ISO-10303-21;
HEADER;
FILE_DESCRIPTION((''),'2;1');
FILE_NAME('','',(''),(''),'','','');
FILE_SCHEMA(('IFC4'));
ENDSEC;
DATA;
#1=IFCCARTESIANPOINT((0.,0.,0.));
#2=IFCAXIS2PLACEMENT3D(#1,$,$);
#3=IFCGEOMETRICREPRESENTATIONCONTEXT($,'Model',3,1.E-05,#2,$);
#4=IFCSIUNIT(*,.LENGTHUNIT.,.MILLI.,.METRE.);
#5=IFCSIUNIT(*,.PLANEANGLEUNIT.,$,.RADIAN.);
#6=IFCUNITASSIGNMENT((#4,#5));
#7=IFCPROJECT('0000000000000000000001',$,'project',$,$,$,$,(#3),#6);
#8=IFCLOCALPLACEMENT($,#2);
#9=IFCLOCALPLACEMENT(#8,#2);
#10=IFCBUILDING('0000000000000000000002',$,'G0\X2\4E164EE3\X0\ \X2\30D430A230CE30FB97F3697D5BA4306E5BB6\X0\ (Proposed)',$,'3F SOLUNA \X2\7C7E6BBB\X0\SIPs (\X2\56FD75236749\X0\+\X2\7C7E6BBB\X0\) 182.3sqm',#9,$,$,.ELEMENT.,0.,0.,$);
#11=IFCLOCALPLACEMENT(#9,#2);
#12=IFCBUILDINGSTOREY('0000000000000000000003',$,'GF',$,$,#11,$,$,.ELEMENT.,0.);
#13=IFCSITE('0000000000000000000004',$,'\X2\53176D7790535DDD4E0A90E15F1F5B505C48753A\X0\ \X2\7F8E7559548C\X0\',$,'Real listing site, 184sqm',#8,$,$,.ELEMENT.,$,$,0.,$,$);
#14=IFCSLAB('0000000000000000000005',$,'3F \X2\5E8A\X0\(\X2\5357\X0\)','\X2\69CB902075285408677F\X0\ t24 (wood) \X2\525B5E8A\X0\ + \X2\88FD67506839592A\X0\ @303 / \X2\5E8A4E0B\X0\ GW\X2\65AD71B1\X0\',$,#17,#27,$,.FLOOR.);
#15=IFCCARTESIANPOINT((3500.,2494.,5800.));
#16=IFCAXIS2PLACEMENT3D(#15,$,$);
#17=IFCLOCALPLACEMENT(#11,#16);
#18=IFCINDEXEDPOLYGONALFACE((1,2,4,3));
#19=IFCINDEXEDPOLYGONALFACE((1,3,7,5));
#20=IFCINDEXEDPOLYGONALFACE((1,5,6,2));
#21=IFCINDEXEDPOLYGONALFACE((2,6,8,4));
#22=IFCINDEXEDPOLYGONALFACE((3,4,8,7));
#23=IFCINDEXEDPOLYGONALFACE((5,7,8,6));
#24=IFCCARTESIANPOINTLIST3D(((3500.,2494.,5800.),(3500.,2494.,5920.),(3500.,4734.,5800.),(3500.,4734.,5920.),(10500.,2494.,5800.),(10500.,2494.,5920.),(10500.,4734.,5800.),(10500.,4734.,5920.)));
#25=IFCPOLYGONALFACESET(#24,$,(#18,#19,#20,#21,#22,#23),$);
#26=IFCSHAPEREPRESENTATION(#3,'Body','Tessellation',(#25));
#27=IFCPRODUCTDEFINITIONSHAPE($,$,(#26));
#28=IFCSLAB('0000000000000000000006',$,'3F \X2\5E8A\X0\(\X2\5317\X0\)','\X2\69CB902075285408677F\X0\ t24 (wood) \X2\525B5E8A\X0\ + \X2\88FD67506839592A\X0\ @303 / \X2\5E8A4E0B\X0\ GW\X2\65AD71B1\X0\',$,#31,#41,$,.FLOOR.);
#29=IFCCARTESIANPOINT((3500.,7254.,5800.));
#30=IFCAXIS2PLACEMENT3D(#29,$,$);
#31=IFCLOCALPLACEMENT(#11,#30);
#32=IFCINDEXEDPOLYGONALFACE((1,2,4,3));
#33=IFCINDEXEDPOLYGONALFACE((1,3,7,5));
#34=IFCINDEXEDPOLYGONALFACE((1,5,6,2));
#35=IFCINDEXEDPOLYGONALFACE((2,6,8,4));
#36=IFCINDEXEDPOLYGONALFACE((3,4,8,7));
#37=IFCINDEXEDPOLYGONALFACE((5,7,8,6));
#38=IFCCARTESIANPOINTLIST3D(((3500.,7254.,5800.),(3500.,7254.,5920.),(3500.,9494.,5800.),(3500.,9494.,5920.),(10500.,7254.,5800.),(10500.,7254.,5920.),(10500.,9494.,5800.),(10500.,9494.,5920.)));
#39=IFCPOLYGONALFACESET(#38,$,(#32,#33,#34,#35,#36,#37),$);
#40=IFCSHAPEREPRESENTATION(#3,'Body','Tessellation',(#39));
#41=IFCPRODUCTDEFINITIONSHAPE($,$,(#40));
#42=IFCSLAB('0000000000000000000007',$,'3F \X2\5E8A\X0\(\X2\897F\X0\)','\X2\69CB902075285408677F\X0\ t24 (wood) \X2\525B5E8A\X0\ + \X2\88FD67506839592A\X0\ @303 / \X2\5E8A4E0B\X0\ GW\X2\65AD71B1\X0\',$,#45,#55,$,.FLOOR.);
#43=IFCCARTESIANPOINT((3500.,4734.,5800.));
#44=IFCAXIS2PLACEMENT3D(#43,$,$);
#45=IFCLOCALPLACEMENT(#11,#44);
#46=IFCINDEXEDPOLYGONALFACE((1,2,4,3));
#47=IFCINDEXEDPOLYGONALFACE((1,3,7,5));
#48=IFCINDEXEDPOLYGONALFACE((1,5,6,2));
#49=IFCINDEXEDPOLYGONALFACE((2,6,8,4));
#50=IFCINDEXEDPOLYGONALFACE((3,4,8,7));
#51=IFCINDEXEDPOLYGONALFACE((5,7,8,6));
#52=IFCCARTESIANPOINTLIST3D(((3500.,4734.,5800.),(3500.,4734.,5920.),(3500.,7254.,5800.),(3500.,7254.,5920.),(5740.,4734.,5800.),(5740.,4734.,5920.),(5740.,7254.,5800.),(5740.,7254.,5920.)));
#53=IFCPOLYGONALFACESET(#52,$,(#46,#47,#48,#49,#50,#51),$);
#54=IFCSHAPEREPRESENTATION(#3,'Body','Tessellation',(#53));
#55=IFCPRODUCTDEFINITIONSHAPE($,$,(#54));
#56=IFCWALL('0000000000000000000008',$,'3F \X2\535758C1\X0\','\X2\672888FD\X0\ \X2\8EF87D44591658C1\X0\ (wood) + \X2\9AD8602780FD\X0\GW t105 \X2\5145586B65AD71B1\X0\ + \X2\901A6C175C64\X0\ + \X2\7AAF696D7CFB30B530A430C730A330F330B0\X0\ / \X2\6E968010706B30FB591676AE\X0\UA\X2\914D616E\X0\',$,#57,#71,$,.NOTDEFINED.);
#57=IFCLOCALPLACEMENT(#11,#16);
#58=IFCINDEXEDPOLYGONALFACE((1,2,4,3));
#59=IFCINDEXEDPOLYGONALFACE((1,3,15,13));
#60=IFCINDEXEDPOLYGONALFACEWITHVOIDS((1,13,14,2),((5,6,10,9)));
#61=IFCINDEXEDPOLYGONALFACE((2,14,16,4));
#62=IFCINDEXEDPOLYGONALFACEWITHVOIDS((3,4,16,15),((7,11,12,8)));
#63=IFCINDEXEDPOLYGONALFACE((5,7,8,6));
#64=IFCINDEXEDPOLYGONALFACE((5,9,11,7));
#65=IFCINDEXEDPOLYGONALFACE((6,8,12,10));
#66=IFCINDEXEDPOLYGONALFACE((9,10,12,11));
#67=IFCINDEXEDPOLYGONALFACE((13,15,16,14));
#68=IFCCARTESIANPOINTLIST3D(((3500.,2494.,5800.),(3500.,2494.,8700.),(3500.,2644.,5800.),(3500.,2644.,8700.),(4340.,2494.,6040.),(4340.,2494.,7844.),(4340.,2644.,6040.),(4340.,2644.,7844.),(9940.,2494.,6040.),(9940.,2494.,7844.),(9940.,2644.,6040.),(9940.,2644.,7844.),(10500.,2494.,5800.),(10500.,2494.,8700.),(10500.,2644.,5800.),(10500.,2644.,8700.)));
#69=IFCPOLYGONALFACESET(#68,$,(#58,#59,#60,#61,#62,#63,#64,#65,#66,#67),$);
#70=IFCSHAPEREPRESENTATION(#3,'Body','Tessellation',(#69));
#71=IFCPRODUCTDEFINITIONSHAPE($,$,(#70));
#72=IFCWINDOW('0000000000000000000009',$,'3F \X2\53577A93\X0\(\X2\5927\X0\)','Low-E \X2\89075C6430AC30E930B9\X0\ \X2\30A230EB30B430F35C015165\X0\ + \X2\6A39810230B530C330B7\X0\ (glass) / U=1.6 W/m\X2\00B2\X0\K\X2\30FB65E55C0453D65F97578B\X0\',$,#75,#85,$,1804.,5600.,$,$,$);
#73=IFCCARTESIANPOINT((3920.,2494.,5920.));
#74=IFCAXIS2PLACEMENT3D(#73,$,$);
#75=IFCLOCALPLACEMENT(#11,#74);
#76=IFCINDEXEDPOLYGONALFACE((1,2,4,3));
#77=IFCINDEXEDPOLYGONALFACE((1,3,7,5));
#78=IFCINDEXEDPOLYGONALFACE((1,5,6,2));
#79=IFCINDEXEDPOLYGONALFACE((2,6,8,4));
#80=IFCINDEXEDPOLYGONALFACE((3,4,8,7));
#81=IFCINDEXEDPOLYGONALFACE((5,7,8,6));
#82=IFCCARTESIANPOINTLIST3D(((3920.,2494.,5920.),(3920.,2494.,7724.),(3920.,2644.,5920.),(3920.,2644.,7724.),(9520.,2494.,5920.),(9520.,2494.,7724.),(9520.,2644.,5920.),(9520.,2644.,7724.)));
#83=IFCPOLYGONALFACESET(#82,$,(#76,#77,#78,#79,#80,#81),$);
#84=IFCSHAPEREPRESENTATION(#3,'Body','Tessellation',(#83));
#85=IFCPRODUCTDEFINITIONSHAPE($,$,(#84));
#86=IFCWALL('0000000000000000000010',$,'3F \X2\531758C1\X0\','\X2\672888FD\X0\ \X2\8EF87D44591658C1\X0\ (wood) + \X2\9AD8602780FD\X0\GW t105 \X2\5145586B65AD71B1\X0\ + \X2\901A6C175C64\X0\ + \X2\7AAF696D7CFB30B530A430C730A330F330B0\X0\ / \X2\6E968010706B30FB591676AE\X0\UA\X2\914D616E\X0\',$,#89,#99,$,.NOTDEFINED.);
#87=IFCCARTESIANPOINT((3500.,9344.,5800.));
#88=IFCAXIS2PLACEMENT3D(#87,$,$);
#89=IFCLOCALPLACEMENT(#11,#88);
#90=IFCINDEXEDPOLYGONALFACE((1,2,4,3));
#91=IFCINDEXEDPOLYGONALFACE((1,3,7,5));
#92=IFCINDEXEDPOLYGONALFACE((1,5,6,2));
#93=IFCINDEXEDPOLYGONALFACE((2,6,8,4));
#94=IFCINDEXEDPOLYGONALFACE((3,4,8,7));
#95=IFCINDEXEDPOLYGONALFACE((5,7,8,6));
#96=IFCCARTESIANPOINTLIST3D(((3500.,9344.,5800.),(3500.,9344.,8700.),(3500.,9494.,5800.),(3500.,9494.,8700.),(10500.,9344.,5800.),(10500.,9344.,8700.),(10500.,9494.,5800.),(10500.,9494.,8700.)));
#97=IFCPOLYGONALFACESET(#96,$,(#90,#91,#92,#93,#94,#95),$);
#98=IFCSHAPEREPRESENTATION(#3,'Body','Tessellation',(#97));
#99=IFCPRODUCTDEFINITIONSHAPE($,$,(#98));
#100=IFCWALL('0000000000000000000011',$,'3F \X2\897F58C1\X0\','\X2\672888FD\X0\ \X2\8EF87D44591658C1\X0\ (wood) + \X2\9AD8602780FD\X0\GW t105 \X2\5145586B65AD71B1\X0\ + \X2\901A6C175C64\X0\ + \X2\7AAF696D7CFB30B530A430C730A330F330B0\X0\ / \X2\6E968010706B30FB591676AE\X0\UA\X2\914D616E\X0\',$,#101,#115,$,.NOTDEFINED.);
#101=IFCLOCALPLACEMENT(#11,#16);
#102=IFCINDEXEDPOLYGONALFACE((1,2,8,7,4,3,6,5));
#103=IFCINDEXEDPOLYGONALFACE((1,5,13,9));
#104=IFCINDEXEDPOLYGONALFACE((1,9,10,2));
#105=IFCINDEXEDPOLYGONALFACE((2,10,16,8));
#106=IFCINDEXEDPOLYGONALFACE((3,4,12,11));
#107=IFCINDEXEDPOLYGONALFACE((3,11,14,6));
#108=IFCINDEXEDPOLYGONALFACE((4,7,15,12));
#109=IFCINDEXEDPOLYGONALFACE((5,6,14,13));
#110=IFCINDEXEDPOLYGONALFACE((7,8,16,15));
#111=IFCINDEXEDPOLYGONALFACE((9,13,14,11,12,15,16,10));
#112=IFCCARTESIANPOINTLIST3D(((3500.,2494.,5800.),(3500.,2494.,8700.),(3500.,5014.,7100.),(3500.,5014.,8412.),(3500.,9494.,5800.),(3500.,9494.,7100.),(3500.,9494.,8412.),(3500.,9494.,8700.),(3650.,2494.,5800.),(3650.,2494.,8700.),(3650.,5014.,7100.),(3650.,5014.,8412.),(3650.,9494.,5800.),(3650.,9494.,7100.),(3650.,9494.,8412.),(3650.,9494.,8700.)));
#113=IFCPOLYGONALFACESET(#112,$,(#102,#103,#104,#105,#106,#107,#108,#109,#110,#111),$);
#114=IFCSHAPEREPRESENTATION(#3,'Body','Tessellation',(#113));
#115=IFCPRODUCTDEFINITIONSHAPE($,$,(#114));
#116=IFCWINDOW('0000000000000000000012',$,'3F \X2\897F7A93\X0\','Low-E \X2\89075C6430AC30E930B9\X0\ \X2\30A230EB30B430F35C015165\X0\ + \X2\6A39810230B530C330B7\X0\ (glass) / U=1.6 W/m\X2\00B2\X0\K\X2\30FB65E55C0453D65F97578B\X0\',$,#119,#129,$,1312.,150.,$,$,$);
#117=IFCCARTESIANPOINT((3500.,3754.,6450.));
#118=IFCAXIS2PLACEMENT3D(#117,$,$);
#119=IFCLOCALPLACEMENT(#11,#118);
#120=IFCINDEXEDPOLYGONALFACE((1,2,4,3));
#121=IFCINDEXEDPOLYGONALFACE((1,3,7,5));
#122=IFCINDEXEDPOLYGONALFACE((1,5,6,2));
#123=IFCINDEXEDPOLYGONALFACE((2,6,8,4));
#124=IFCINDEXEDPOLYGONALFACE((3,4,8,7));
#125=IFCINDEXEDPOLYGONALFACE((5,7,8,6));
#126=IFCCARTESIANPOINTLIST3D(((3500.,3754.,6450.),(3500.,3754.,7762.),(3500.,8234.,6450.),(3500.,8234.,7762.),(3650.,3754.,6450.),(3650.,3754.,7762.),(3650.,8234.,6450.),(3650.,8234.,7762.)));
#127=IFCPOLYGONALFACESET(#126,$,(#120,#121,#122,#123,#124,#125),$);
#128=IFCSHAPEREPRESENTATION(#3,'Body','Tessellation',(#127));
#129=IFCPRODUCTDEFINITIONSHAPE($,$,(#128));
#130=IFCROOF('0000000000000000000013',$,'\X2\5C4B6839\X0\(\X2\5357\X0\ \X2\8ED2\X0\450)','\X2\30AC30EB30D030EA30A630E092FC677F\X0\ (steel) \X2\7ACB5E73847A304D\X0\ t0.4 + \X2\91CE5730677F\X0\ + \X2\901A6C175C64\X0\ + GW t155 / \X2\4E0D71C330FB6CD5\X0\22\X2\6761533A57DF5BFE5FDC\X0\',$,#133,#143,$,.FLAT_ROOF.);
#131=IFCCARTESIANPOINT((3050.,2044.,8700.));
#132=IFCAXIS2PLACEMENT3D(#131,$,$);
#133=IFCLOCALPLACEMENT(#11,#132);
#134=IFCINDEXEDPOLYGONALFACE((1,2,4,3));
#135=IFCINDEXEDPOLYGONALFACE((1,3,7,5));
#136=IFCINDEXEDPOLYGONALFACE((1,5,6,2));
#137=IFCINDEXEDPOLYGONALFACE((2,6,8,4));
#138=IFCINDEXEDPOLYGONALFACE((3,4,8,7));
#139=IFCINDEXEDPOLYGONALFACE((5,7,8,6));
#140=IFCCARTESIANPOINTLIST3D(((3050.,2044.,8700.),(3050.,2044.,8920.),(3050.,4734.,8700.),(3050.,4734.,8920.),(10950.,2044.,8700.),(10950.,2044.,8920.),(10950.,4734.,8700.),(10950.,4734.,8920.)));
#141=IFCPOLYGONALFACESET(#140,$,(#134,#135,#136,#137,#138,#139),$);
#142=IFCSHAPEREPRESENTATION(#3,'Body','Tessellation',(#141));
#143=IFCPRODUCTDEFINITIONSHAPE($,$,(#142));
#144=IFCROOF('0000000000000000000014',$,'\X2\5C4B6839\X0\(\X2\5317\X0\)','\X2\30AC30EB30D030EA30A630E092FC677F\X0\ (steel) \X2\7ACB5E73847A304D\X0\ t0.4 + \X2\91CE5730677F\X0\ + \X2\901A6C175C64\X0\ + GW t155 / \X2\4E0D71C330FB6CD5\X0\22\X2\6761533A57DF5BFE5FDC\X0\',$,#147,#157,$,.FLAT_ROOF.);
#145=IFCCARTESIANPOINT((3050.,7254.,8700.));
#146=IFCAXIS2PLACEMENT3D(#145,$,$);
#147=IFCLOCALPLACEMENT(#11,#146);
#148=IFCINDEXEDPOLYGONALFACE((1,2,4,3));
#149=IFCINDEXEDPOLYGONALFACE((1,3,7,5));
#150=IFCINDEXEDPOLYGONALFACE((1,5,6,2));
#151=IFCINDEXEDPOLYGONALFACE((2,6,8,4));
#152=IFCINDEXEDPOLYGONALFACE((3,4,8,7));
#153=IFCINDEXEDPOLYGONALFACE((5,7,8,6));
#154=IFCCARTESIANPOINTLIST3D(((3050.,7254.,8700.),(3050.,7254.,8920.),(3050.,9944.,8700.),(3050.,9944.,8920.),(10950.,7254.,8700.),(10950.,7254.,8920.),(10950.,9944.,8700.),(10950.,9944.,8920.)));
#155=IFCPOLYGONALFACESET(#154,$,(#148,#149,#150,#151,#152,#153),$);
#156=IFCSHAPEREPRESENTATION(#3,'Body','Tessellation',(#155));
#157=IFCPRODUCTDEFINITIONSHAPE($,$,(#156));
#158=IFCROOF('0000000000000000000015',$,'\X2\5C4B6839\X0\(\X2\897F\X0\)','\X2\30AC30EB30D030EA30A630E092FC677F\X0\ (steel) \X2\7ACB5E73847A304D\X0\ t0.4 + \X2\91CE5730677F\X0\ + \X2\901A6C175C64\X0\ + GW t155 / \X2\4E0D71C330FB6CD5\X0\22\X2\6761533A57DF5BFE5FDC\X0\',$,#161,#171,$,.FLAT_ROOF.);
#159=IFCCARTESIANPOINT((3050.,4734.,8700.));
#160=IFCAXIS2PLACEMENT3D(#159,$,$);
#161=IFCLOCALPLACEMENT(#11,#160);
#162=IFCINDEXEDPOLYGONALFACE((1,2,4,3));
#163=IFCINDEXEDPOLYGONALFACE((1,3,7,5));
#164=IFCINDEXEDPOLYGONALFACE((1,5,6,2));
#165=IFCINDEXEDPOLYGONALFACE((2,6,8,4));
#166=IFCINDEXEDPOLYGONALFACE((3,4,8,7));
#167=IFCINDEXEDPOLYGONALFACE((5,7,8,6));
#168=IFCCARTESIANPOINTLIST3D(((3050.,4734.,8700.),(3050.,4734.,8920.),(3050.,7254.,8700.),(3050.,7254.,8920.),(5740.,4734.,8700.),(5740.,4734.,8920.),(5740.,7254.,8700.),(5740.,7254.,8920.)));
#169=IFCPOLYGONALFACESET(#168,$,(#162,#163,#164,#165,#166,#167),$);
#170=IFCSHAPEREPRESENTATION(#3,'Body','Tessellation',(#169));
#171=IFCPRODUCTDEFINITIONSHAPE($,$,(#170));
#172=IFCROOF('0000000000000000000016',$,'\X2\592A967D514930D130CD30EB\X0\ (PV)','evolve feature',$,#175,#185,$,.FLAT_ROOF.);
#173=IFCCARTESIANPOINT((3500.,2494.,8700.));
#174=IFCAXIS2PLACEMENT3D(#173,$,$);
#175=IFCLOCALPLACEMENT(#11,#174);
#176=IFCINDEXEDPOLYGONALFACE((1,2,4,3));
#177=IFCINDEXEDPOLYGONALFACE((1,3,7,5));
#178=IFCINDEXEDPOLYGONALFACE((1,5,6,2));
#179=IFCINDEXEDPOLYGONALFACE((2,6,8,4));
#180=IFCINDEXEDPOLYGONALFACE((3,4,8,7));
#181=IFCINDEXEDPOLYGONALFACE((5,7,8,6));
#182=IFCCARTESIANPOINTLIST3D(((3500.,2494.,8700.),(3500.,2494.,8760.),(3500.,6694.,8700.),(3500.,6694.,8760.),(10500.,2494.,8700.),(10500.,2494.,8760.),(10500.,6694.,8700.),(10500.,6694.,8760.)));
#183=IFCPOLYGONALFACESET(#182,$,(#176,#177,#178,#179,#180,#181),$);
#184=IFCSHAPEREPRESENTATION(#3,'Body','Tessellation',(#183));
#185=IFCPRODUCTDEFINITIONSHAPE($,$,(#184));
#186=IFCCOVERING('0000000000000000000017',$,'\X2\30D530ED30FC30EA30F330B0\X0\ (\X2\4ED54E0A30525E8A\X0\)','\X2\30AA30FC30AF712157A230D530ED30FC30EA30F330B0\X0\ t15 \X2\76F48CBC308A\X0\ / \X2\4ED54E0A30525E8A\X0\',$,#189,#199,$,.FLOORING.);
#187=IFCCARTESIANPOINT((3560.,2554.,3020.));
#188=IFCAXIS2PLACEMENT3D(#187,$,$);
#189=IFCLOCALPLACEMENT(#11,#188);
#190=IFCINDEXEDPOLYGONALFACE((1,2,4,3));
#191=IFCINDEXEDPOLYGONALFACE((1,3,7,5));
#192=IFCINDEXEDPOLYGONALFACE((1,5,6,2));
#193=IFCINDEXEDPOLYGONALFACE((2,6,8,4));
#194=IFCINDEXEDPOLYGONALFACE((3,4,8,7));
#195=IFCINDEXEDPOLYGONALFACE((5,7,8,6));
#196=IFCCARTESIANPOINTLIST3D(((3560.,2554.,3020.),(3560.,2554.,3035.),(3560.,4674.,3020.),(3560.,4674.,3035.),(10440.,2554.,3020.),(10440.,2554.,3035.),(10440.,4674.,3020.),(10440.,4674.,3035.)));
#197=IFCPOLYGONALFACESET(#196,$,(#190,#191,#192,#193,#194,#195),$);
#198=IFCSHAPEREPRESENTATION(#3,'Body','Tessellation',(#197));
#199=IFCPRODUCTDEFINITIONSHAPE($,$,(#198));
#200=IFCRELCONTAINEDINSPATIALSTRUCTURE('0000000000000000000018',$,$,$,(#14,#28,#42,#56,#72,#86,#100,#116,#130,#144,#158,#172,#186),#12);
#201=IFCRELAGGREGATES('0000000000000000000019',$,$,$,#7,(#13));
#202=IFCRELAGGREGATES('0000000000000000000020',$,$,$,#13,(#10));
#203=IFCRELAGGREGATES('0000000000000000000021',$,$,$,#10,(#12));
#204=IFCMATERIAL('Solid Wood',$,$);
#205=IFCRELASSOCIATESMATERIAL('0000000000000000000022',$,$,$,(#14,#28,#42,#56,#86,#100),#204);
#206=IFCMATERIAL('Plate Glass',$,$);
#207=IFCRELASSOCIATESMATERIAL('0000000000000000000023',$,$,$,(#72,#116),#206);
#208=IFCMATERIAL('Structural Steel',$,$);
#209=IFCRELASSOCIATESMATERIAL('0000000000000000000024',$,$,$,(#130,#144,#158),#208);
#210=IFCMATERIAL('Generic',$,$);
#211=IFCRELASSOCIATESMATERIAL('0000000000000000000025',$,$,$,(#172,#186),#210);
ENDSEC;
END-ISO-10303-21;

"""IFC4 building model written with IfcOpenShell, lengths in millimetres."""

from ifc_helpers import new_model, si_unit, frame, frame_2d, origin, place, context, project, spatial, rectangle, extrude, material, element, fill, save


model = new_model("IFC4")

# Units and contexts
model_context = context("Model", 3, precision=1e-05, world=origin())
ifc_project = project(units=[si_unit("LENGTHUNIT", "METRE", prefix="MILLI"), si_unit("PLANEANGLEUNIT", "RADIAN")], contexts=[model_context])

# Site, building, storey
site_placement = place(None, origin())
site = spatial("IfcSite", under=ifc_project, at=site_placement, Name="北海道川上郡弟子屈町 美留和", ObjectType="Real listing site, 184sqm", CompositionType="ELEMENT", RefElevation=0.0)
building_placement = place(site_placement, origin())
building = spatial("IfcBuilding", under=site, at=building_placement, Name="G0世代 ピアノ・音楽室の家 (Proposed)", ObjectType="3F SOLUNA 籾殻SIPs (国産杉+籾殻) 182.3sqm", CompositionType="ELEMENT", ElevationOfRefHeight=0.0, ElevationOfTerrain=0.0)
storey_placement = place(building_placement, origin())
storey = spatial("IfcBuildingStorey", under=building, at=storey_placement, Name="GF", CompositionType="ELEMENT", Elevation=0.0)

# Slabs
ifc_material_1 = material(Name="Solid Wood")
slab_1_placement = place(storey_placement, frame((3500.0, 2494.0, 5800.0)))
element("IfcSlab", 1, at=slab_1_placement, inside=storey, material=ifc_material_1, Name="3F 床(南)", Description="構造用合板 t24 (wood) 剛床 + 製材根太 @303 / 床下 GW断熱", PredefinedType="FLOOR", context=model_context, shape_type="SweptSolid", body=[
    extrude(rectangle(XDim=7000.0, YDim=2240.0, at=frame_2d((3500.0, 1120.0))), frame((3500.0, 2494.0, 5800.0)), (0.0, 0.0, 1.0), 120.0),
])
slab_2_placement = place(storey_placement, frame((3500.0, 7254.0, 5800.0)))
element("IfcSlab", 2, at=slab_2_placement, inside=storey, material=ifc_material_1, Name="3F 床(北)", Description="構造用合板 t24 (wood) 剛床 + 製材根太 @303 / 床下 GW断熱", PredefinedType="FLOOR", context=model_context, shape_type="SweptSolid", body=[
    extrude(rectangle(XDim=7000.0, YDim=2240.0, at=frame_2d((3500.0, 1120.0))), frame((3500.0, 7254.0, 5800.0)), (0.0, 0.0, 1.0), 120.0),
])
slab_3_placement = place(storey_placement, frame((3500.0, 4734.0, 5800.0)))
element("IfcSlab", 3, at=slab_3_placement, inside=storey, material=ifc_material_1, Name="3F 床(西)", Description="構造用合板 t24 (wood) 剛床 + 製材根太 @303 / 床下 GW断熱", PredefinedType="FLOOR", context=model_context, shape_type="SweptSolid", body=[
    extrude(rectangle(XDim=2240.0, YDim=2520.0, at=frame_2d((1120.0, 1260.0))), frame((3500.0, 4734.0, 5800.0)), (0.0, 0.0, 1.0), 120.0),
])

# Wall, opening, window
wall_1_placement = place(storey_placement, frame((3500.0, 2494.0, 5800.0)))
wall_1 = element("IfcWall", 4, at=wall_1_placement, inside=storey, material=ifc_material_1, Name="3F 南壁", Description="木製 軸組外壁 (wood) + 高性能GW t105 充填断熱 + 通気層 + 窯業系サイディング / 準耐火・外皮UA配慮", PredefinedType="NOTDEFINED", context=model_context, shape_type="SweptSolid", body=[
    extrude(rectangle(XDim=7000.0, YDim=150.0, at=frame_2d((3500.0, 75.0))), frame((3500.0, 2494.0, 5800.0)), (0.0, 0.0, 1.0), 2900.0),
])
opening_1_placement = place(storey_placement, frame((3920.0, 2494.0, 5920.0)))
opening_1 = element("IfcOpeningElement", 5, at=opening_1_placement, cuts=wall_1, PredefinedType="NOTDEFINED", context=model_context, shape_type="SweptSolid", body=[
    extrude(rectangle(XDim=5600.0, YDim=150.0, at=frame_2d((2800.0, 75.0))), frame((3920.0, 2494.0, 5920.0)), (0.0, 0.0, 1.0), 1804.0),
])
ifc_material_2 = material(Name="Plate Glass")
window_1_placement = place(storey_placement, frame((3920.0, 2494.0, 5920.0)))
window_1 = element("IfcWindow", 6, at=window_1_placement, inside=storey, material=ifc_material_2, Name="3F 南窓(大)", Description="Low-E 複層ガラス アルゴン封入 + 樹脂サッシ (glass) / U=1.6 W/m²K・日射取得型", OverallHeight=1804.0, OverallWidth=5600.0, context=model_context, shape_type="SweptSolid", body=[
    extrude(rectangle(XDim=5600.0, YDim=150.0, at=frame_2d((2800.0, 75.0))), frame((3920.0, 2494.0, 5920.0)), (0.0, 0.0, 1.0), 1804.0),
])
fill(opening_1, window_1)

# Wall
wall_2_placement = place(storey_placement, frame((3500.0, 9344.0, 5800.0)))
element("IfcWall", 7, at=wall_2_placement, inside=storey, material=ifc_material_1, Name="3F 北壁", Description="木製 軸組外壁 (wood) + 高性能GW t105 充填断熱 + 通気層 + 窯業系サイディング / 準耐火・外皮UA配慮", PredefinedType="NOTDEFINED", context=model_context, shape_type="SweptSolid", body=[
    extrude(rectangle(XDim=7000.0, YDim=150.0, at=frame_2d((3500.0, 75.0))), frame((3500.0, 9344.0, 5800.0)), (0.0, 0.0, 1.0), 2900.0),
])

# Wall, opening, window
wall_3_placement = place(storey_placement, frame((3500.0, 2494.0, 5800.0)))
wall_3 = element("IfcWall", 8, at=wall_3_placement, inside=storey, material=ifc_material_1, Name="3F 西壁", Description="木製 軸組外壁 (wood) + 高性能GW t105 充填断熱 + 通気層 + 窯業系サイディング / 準耐火・外皮UA配慮", PredefinedType="NOTDEFINED", context=model_context, shape_type="SweptSolid", body=[
    extrude(rectangle(XDim=150.0, YDim=7000.0, at=frame_2d((75.0, 3500.0))), frame((3500.0, 2494.0, 5800.0)), (0.0, 0.0, 1.0), 2900.0),
])
opening_2_placement = place(storey_placement, frame((3500.0, 3754.0, 6450.0)))
opening_2 = element("IfcOpeningElement", 9, at=opening_2_placement, cuts=wall_3, PredefinedType="NOTDEFINED", context=model_context, shape_type="SweptSolid", body=[
    extrude(rectangle(XDim=150.0, YDim=4480.0, at=frame_2d((75.0, 2240.0))), frame((3500.0, 3754.0, 6450.0)), (0.0, 0.0, 1.0), 1312.0),
])
window_2_placement = place(storey_placement, frame((3500.0, 3754.0, 6450.0)))
window_2 = element("IfcWindow", 10, at=window_2_placement, inside=storey, material=ifc_material_2, Name="3F 西窓", Description="Low-E 複層ガラス アルゴン封入 + 樹脂サッシ (glass) / U=1.6 W/m²K・日射取得型", OverallHeight=1312.0, OverallWidth=150.0, context=model_context, shape_type="SweptSolid", body=[
    extrude(rectangle(XDim=150.0, YDim=4480.0, at=frame_2d((75.0, 2240.0))), frame((3500.0, 3754.0, 6450.0)), (0.0, 0.0, 1.0), 1312.0),
])
fill(opening_2, window_2)

# Roofs
ifc_material_3 = material(Name="Structural Steel")
roof_1_placement = place(storey_placement, frame((3050.0, 2044.0, 8700.0)))
element("IfcRoof", 11, at=roof_1_placement, inside=storey, material=ifc_material_3, Name="屋根(南 軒450)", Description="ガルバリウム鋼板 (steel) 立平葺き t0.4 + 野地板 + 通気層 + GW t155 / 不燃・法22条区域対応", PredefinedType="FLAT_ROOF", context=model_context, shape_type="SweptSolid", body=[
    extrude(rectangle(XDim=7900.0, YDim=2690.0, at=frame_2d((3950.0, 1345.0))), frame((3050.0, 2044.0, 8700.0)), (0.0, 0.0, 1.0), 220.0),
])
roof_2_placement = place(storey_placement, frame((3050.0, 7254.0, 8700.0)))
element("IfcRoof", 12, at=roof_2_placement, inside=storey, material=ifc_material_3, Name="屋根(北)", Description="ガルバリウム鋼板 (steel) 立平葺き t0.4 + 野地板 + 通気層 + GW t155 / 不燃・法22条区域対応", PredefinedType="FLAT_ROOF", context=model_context, shape_type="SweptSolid", body=[
    extrude(rectangle(XDim=7900.0, YDim=2690.0, at=frame_2d((3950.0, 1345.0))), frame((3050.0, 7254.0, 8700.0)), (0.0, 0.0, 1.0), 220.0),
])
roof_3_placement = place(storey_placement, frame((3050.0, 4734.0, 8700.0)))
element("IfcRoof", 13, at=roof_3_placement, inside=storey, material=ifc_material_3, Name="屋根(西)", Description="ガルバリウム鋼板 (steel) 立平葺き t0.4 + 野地板 + 通気層 + GW t155 / 不燃・法22条区域対応", PredefinedType="FLAT_ROOF", context=model_context, shape_type="SweptSolid", body=[
    extrude(rectangle(XDim=2690.0, YDim=2520.0, at=frame_2d((1345.0, 1260.0))), frame((3050.0, 4734.0, 8700.0)), (0.0, 0.0, 1.0), 220.0),
])
ifc_material_4 = material(Name="Generic")
roof_4_placement = place(storey_placement, frame((3500.0, 2494.0, 8700.0)))
element("IfcRoof", 14, at=roof_4_placement, inside=storey, material=ifc_material_4, Name="太陽光パネル (PV)", Description="evolve feature", PredefinedType="FLAT_ROOF", context=model_context, shape_type="SweptSolid", body=[
    extrude(rectangle(XDim=7000.0, YDim=4200.0, at=frame_2d((3500.0, 2100.0))), frame((3500.0, 2494.0, 8700.0)), (0.0, 0.0, 1.0), 60.0),
])

# Covering
covering_1_placement = place(storey_placement, frame((3560.0, 2554.0, 3020.0)))
element("IfcCovering", 15, at=covering_1_placement, inside=storey, material=ifc_material_4, Name="フローリング (仕上げ床)", Description="オーク無垢フローリング t15 直貼り / 仕上げ床", PredefinedType="FLOORING", context=model_context, shape_type="SweptSolid", body=[
    extrude(rectangle(XDim=6880.0, YDim=2120.0, at=frame_2d((3440.0, 1060.0))), frame((3560.0, 2554.0, 3020.0)), (0.0, 0.0, 1.0), 15.0),
])

save(model, "model.ifc")
